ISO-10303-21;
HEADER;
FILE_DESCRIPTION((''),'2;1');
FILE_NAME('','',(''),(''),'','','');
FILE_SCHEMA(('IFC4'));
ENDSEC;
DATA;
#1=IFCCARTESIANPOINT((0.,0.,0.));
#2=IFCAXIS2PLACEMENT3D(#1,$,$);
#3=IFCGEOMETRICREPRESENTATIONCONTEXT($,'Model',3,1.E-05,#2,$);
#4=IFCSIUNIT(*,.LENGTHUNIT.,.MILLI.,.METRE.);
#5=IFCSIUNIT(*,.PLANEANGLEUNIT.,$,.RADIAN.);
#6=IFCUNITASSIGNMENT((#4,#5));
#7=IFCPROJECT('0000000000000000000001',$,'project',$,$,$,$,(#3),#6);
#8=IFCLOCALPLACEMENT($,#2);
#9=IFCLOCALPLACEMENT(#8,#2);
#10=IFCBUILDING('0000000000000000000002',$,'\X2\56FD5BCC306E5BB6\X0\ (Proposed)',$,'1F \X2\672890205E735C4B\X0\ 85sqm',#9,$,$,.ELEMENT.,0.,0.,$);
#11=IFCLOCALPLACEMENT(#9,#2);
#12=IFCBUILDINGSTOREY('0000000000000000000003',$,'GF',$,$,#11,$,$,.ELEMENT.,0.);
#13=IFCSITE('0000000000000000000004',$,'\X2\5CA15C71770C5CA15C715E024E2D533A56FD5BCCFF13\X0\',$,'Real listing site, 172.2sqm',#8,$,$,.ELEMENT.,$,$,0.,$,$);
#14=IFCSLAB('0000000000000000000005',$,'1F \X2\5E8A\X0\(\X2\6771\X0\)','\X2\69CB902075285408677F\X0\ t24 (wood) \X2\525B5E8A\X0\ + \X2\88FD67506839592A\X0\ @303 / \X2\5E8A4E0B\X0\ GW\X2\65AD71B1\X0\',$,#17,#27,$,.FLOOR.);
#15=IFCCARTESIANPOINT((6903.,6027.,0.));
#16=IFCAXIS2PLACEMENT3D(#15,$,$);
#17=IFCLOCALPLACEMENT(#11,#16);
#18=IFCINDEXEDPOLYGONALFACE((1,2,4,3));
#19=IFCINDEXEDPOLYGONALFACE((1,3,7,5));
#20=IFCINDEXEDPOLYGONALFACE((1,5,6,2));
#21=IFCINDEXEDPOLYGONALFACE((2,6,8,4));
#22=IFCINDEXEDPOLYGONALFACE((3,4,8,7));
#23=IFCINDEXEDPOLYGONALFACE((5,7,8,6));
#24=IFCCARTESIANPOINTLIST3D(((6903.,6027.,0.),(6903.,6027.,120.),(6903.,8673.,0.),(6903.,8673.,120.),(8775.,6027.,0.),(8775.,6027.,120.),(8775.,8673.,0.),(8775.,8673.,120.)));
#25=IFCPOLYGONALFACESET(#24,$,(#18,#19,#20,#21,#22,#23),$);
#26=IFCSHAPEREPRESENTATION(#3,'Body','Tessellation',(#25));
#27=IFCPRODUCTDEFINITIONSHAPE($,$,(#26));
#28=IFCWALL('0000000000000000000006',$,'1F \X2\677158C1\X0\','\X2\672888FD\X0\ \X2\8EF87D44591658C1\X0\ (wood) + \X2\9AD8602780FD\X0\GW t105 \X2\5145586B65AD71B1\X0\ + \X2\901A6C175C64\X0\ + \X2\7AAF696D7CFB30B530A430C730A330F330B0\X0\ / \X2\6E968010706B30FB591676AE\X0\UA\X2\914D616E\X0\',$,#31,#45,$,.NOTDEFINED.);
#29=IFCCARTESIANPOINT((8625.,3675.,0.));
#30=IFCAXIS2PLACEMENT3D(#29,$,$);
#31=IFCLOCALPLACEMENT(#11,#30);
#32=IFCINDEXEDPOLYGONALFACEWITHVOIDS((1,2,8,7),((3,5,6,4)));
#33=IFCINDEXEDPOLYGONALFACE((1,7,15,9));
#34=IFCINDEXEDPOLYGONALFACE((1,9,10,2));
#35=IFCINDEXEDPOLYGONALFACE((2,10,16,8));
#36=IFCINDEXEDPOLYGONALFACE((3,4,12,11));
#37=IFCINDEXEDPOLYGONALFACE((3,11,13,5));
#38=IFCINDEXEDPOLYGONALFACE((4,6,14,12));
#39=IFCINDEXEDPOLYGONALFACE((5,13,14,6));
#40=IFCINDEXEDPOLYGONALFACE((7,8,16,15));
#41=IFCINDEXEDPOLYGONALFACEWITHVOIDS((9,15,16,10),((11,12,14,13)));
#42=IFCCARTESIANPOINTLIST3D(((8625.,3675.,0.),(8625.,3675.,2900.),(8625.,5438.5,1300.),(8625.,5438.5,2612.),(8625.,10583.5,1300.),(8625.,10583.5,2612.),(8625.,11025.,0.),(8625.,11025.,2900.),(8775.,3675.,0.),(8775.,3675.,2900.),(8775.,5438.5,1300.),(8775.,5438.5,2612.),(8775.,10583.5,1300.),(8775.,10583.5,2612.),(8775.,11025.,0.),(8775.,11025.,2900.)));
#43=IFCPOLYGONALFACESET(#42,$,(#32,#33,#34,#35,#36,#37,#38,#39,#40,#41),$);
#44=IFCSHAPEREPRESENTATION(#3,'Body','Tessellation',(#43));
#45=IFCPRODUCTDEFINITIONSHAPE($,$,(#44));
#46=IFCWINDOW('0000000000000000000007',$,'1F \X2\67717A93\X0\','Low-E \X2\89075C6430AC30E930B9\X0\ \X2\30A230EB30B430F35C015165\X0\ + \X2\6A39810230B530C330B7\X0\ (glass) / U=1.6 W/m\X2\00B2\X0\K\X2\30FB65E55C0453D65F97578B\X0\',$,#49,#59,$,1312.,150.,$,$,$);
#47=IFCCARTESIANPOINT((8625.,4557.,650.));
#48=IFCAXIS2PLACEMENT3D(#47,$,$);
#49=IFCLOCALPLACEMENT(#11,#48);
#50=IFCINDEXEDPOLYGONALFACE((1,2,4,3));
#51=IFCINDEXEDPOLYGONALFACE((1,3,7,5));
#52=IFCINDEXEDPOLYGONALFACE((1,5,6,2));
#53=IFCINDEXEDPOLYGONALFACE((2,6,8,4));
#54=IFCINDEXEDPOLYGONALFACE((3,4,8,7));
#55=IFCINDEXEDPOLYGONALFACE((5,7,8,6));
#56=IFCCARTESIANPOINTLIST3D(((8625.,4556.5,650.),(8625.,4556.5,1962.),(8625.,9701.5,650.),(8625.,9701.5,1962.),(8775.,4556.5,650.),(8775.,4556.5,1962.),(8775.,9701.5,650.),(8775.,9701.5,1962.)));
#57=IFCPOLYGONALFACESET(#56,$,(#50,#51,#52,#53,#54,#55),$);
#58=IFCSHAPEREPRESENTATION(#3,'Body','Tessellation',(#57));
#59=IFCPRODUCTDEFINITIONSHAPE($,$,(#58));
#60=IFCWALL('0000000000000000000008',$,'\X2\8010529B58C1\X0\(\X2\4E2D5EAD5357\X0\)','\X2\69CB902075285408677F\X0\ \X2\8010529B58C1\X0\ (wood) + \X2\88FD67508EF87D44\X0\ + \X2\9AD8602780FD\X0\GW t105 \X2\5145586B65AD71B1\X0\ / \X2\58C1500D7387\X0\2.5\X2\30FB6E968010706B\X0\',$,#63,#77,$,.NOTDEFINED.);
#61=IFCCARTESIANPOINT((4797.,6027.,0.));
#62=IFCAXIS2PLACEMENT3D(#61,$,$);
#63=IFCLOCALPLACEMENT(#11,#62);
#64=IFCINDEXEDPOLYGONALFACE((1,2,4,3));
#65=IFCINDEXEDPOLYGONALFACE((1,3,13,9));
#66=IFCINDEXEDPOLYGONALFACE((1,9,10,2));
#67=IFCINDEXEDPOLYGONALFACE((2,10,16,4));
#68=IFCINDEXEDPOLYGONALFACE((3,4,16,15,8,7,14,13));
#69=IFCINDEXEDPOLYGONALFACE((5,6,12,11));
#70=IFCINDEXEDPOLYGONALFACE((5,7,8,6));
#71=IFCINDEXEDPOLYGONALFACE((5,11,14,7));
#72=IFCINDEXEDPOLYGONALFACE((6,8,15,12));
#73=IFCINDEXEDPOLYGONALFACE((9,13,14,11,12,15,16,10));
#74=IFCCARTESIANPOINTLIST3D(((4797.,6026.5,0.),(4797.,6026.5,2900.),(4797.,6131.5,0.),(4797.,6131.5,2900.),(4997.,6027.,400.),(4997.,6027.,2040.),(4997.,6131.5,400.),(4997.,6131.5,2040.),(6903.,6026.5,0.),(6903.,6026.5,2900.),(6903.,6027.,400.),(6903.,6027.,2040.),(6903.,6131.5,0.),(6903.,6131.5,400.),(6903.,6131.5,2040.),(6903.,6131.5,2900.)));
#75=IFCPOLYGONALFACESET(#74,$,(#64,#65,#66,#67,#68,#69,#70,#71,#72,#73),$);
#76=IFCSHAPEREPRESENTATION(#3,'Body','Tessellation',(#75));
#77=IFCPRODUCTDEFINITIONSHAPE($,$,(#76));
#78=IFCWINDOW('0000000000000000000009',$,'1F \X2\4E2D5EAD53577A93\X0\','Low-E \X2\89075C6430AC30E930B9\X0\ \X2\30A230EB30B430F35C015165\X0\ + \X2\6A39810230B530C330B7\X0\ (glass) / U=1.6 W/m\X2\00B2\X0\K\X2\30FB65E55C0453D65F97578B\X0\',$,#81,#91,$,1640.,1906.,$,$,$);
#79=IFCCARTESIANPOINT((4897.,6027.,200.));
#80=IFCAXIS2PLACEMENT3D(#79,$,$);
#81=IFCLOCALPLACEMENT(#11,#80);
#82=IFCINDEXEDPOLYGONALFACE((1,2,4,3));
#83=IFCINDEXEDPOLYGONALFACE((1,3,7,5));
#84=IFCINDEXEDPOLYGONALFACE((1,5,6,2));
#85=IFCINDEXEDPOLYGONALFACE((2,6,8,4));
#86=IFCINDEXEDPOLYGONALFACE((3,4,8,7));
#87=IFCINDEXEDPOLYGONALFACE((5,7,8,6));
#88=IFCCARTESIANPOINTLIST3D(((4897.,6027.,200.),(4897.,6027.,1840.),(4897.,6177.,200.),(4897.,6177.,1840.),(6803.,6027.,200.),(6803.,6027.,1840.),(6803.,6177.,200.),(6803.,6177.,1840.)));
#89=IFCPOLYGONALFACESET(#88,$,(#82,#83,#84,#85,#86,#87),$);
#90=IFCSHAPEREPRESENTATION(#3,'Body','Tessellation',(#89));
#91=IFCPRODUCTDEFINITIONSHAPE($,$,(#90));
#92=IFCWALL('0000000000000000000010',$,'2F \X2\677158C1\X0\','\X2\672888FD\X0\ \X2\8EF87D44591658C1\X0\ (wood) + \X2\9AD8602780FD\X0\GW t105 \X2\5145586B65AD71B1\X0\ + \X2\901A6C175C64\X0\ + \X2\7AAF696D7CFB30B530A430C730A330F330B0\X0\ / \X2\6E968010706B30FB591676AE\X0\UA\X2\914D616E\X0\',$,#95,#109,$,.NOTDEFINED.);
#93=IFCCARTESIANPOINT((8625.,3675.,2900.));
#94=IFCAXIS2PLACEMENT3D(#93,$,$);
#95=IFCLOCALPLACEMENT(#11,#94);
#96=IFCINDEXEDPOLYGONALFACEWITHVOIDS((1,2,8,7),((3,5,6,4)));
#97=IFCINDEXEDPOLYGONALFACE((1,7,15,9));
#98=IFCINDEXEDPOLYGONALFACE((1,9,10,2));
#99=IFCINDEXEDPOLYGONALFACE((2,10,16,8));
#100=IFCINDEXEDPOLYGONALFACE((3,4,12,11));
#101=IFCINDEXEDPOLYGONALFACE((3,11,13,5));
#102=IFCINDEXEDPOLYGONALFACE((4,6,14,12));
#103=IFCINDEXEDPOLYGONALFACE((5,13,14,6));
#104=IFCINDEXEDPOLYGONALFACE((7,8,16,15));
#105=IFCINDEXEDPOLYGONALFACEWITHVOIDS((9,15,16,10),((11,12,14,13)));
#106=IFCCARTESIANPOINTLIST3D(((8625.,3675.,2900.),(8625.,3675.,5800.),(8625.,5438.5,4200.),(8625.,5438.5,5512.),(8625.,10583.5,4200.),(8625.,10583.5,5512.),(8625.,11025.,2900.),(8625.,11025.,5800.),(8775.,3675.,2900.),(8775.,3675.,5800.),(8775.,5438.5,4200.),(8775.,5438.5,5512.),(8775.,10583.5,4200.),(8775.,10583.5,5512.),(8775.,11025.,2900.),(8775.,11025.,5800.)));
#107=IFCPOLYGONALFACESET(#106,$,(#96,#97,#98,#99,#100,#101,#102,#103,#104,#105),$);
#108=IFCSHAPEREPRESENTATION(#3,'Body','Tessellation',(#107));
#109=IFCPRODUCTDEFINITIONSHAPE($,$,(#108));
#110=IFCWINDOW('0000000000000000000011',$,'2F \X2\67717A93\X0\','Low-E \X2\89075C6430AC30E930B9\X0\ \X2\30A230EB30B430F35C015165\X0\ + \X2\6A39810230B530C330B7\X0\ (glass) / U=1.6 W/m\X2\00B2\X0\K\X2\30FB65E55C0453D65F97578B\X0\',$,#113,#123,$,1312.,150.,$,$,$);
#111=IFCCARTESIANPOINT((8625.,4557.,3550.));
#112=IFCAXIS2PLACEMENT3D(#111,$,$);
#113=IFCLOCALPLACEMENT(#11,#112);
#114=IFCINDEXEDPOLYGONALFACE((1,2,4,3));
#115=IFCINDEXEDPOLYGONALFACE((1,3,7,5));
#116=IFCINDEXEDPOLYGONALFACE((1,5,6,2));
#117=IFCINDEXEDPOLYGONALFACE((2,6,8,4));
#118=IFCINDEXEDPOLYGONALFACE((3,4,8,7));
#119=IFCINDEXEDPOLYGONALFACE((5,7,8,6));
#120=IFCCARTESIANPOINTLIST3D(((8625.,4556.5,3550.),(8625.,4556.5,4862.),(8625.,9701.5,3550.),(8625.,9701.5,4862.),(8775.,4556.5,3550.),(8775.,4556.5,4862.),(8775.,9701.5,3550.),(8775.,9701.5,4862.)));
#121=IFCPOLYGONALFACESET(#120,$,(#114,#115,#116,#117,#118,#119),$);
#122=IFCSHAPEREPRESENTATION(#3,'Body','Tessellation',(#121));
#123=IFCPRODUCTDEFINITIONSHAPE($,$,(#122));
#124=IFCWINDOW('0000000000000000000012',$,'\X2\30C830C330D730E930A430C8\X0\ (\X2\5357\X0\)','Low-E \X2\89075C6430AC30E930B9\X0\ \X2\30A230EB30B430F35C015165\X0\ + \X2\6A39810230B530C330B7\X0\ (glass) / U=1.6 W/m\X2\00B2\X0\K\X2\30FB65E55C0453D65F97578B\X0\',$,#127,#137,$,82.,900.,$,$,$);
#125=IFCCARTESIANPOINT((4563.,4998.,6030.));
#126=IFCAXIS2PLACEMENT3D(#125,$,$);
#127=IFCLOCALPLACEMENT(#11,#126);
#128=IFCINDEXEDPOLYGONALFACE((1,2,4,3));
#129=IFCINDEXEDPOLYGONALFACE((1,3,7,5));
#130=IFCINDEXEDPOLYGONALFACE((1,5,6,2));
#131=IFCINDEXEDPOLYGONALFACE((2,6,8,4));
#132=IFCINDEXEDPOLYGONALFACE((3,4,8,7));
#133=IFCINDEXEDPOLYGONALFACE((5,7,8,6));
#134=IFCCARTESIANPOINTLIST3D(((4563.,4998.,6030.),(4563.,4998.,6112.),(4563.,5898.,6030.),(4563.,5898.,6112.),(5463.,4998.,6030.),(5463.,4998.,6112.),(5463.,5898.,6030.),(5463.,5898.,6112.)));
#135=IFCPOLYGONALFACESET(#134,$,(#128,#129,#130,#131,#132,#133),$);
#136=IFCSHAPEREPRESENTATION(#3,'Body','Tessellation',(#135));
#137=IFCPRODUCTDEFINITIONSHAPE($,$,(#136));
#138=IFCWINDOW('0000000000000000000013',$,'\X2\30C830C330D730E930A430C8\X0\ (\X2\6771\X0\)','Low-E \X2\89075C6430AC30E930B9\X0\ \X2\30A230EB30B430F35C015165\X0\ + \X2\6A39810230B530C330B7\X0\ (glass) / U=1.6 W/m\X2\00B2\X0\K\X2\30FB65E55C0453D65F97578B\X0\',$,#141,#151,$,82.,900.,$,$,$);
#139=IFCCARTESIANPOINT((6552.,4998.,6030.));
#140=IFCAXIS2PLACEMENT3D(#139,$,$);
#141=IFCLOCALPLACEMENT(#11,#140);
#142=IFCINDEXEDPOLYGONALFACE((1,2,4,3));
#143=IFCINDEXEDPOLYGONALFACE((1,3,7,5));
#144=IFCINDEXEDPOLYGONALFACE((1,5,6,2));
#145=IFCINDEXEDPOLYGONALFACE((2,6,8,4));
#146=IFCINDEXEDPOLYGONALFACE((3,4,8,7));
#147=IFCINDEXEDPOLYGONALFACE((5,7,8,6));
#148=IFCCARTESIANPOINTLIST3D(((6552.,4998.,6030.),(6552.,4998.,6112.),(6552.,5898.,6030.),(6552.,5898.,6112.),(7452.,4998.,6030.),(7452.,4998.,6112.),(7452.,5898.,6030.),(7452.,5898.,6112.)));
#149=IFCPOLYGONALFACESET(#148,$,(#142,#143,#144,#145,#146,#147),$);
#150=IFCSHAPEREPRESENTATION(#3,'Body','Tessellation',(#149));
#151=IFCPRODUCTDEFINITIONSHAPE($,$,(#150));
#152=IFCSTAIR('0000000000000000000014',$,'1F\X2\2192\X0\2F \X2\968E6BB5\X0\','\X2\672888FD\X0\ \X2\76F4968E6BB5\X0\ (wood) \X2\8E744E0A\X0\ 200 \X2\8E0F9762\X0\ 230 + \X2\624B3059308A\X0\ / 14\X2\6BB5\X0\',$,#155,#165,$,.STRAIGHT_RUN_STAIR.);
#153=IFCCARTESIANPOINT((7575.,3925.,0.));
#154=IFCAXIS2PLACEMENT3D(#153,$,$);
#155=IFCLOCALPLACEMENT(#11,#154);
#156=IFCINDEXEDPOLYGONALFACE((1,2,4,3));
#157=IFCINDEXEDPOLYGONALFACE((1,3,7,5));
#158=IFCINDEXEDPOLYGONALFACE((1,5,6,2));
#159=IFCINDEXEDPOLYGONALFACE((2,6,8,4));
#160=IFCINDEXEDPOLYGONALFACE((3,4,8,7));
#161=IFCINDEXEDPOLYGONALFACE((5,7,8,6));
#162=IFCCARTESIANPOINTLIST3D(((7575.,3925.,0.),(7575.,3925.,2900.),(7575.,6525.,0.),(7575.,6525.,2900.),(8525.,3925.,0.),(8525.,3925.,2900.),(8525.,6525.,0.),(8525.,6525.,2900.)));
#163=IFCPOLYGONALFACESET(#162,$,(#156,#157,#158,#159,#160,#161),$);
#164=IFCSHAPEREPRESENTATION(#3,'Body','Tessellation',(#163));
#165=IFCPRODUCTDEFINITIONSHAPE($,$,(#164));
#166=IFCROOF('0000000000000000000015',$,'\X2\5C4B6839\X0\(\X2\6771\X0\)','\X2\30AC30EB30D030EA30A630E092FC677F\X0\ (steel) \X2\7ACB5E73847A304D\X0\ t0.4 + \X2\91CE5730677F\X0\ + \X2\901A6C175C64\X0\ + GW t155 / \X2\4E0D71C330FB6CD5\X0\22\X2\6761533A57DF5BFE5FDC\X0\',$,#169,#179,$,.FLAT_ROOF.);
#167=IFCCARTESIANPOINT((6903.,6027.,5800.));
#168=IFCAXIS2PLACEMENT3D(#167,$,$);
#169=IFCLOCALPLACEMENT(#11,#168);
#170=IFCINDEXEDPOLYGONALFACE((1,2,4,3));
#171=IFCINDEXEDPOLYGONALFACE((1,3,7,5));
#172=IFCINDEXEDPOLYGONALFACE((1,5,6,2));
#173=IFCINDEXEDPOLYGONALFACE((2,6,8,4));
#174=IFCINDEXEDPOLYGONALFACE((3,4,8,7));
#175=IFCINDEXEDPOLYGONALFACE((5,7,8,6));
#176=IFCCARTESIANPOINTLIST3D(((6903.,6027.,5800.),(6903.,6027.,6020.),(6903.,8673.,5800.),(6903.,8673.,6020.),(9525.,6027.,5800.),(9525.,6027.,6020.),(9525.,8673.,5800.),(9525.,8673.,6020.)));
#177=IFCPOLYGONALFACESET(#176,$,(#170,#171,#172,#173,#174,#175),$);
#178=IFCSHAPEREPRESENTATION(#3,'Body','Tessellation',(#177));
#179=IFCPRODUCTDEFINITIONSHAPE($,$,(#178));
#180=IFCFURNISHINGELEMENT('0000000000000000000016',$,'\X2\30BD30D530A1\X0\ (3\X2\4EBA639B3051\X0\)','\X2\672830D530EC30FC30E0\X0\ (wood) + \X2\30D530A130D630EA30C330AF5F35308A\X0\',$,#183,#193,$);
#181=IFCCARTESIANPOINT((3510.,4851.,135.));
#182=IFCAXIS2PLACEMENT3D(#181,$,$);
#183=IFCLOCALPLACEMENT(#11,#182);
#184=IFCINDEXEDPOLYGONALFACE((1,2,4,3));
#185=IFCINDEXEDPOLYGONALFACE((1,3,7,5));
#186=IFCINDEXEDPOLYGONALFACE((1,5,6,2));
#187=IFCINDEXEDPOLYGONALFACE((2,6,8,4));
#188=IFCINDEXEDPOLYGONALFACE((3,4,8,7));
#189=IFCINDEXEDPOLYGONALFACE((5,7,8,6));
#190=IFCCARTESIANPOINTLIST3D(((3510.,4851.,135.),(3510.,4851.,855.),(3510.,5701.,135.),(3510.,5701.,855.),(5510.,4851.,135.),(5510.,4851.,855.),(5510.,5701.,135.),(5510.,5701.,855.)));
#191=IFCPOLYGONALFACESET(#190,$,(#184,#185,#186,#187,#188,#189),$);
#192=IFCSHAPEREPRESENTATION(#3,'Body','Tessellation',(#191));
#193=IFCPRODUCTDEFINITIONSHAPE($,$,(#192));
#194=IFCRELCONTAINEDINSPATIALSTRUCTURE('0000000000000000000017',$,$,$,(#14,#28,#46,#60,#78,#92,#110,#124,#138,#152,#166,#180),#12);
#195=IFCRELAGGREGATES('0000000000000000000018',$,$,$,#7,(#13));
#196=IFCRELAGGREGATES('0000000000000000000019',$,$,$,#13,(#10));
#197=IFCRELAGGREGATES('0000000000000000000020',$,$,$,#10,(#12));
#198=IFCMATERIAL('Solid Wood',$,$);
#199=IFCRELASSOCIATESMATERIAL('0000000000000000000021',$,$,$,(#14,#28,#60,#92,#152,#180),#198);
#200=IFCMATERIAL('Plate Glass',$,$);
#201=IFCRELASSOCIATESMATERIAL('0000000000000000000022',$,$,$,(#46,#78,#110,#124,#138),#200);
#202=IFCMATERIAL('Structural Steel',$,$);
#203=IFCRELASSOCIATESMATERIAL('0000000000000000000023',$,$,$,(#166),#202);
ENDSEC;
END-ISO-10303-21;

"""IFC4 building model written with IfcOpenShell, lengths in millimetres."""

from ifc_helpers import new_model, si_unit, frame, frame_2d, origin, place, context, project, spatial, rectangle, extrude, material, element, fill, save


model = new_model("IFC4")

# Units and contexts
model_context = context("Model", 3, precision=1e-05, world=origin())
ifc_project = project(units=[si_unit("LENGTHUNIT", "METRE", prefix="MILLI"), si_unit("PLANEANGLEUNIT", "RADIAN")], contexts=[model_context])

# Site, building, storey
site_placement = place(None, origin())
site = spatial("IfcSite", under=ifc_project, at=site_placement, Name="岡山県岡山市中区国富３", ObjectType="Real listing site, 172.2sqm", CompositionType="ELEMENT", RefElevation=0.0)
building_placement = place(site_placement, origin())
building = spatial("IfcBuilding", under=site, at=building_placement, Name="国富の家 (Proposed)", ObjectType="1F 木造平屋 85sqm", CompositionType="ELEMENT", ElevationOfRefHeight=0.0, ElevationOfTerrain=0.0)
storey_placement = place(building_placement, origin())
storey = spatial("IfcBuildingStorey", under=building, at=storey_placement, Name="GF", CompositionType="ELEMENT", Elevation=0.0)

# Slab
ifc_material_1 = material(Name="Solid Wood")
slab_placement = place(storey_placement, frame((6903.0, 6027.0, 0.0)))
element("IfcSlab", 1, at=slab_placement, inside=storey, material=ifc_material_1, Name="1F 床(東)", Description="構造用合板 t24 (wood) 剛床 + 製材根太 @303 / 床下 GW断熱", PredefinedType="FLOOR", context=model_context, shape_type="SweptSolid", body=[
    extrude(rectangle(XDim=1872.0, YDim=2646.0, at=frame_2d((936.0, 1323.0))), frame((6903.0, 6027.0, 0.0)), (0.0, 0.0, 1.0), 120.0),
])

# Walls, openings, windows
wall_1_placement = place(storey_placement, frame((8625.0, 3675.0, 0.0)))
wall_1 = element("IfcWall", 2, at=wall_1_placement, inside=storey, material=ifc_material_1, Name="1F 東壁", Description="木製 軸組外壁 (wood) + 高性能GW t105 充填断熱 + 通気層 + 窯業系サイディング / 準耐火・外皮UA配慮", PredefinedType="NOTDEFINED", context=model_context, shape_type="SweptSolid", body=[
    extrude(rectangle(XDim=150.0, YDim=7350.0, at=frame_2d((75.0, 3675.0))), frame((8625.0, 3675.0, 0.0)), (0.0, 0.0, 1.0), 2900.0),
])
opening_1_placement = place(storey_placement, frame((8625.0, 4557.0, 650.0)))
opening_1 = element("IfcOpeningElement", 3, at=opening_1_placement, cuts=wall_1, PredefinedType="NOTDEFINED", context=model_context, shape_type="SweptSolid", body=[
    extrude(rectangle(XDim=150.0, YDim=5145.0, at=frame_2d((75.0, 2572.0))), frame((8625.0, 4557.0, 650.0)), (0.0, 0.0, 1.0), 1312.0),
])
ifc_material_2 = material(Name="Plate Glass")
window_1_placement = place(storey_placement, frame((8625.0, 4557.0, 650.0)))
window_1 = element("IfcWindow", 4, at=window_1_placement, inside=storey, material=ifc_material_2, Name="1F 東窓", Description="Low-E 複層ガラス アルゴン封入 + 樹脂サッシ (glass) / U=1.6 W/m²K・日射取得型", OverallHeight=1312.0, OverallWidth=150.0, context=model_context, shape_type="SweptSolid", body=[
    extrude(rectangle(XDim=150.0, YDim=5145.0, at=frame_2d((75.0, 2572.0))), frame((8625.0, 4557.0, 650.0)), (0.0, 0.0, 1.0), 1312.0),
])
fill(opening_1, window_1)
wall_2_placement = place(storey_placement, frame((4797.0, 6027.0, 0.0)))
wall_2 = element("IfcWall", 5, at=wall_2_placement, inside=storey, material=ifc_material_1, Name="耐力壁(中庭南)", Description="構造用合板 耐力壁 (wood) + 製材軸組 + 高性能GW t105 充填断熱 / 壁倍率2.5・準耐火", PredefinedType="NOTDEFINED", context=model_context, shape_type="SweptSolid", body=[
    extrude(rectangle(XDim=2106.0, YDim=105.0, at=frame_2d((1053.0, 52.0))), frame((4797.0, 6027.0, 0.0)), (0.0, 0.0, 1.0), 2900.0),
])
opening_2_placement = place(storey_placement, frame((4897.0, 6027.0, 200.0)))
opening_2 = element("IfcOpeningElement", 6, at=opening_2_placement, cuts=wall_2, PredefinedType="NOTDEFINED", context=model_context, shape_type="SweptSolid", body=[
    extrude(rectangle(XDim=1906.0, YDim=150.0, at=frame_2d((953.0, 75.0))), frame((4897.0, 6027.0, 200.0)), (0.0, 0.0, 1.0), 1640.0),
])
window_2_placement = place(storey_placement, frame((4897.0, 6027.0, 200.0)))
window_2 = element("IfcWindow", 7, at=window_2_placement, inside=storey, material=ifc_material_2, Name="1F 中庭南窓", Description="Low-E 複層ガラス アルゴン封入 + 樹脂サッシ (glass) / U=1.6 W/m²K・日射取得型", OverallHeight=1640.0, OverallWidth=1906.0, context=model_context, shape_type="SweptSolid", body=[
    extrude(rectangle(XDim=1906.0, YDim=150.0, at=frame_2d((953.0, 75.0))), frame((4897.0, 6027.0, 200.0)), (0.0, 0.0, 1.0), 1640.0),
])
fill(opening_2, window_2)

# Wall, opening, window
wall_3_placement = place(storey_placement, frame((8625.0, 3675.0, 2900.0)))
wall_3 = element("IfcWall", 8, at=wall_3_placement, inside=storey, material=ifc_material_1, Name="2F 東壁", Description="木製 軸組外壁 (wood) + 高性能GW t105 充填断熱 + 通気層 + 窯業系サイディング / 準耐火・外皮UA配慮", PredefinedType="NOTDEFINED", context=model_context, shape_type="SweptSolid", body=[
    extrude(rectangle(XDim=150.0, YDim=7350.0, at=frame_2d((75.0, 3675.0))), frame((8625.0, 3675.0, 2900.0)), (0.0, 0.0, 1.0), 2900.0),
])
opening_3_placement = place(storey_placement, frame((8625.0, 4557.0, 3550.0)))
opening_3 = element("IfcOpeningElement", 9, at=opening_3_placement, cuts=wall_3, PredefinedType="NOTDEFINED", context=model_context, shape_type="SweptSolid", body=[
    extrude(rectangle(XDim=150.0, YDim=5145.0, at=frame_2d((75.0, 2572.0))), frame((8625.0, 4557.0, 3550.0)), (0.0, 0.0, 1.0), 1312.0),
])
window_3_placement = place(storey_placement, frame((8625.0, 4557.0, 3550.0)))
window_3 = element("IfcWindow", 10, at=window_3_placement, inside=storey, material=ifc_material_2, Name="2F 東窓", Description="Low-E 複層ガラス アルゴン封入 + 樹脂サッシ (glass) / U=1.6 W/m²K・日射取得型", OverallHeight=1312.0, OverallWidth=150.0, context=model_context, shape_type="SweptSolid", body=[
    extrude(rectangle(XDim=150.0, YDim=5145.0, at=frame_2d((75.0, 2572.0))), frame((8625.0, 4557.0, 3550.0)), (0.0, 0.0, 1.0), 1312.0),
])
fill(opening_3, window_3)

# Windows
window_4_placement = place(storey_placement, frame((4563.0, 4998.0, 6030.0)))
element("IfcWindow", 11, at=window_4_placement, inside=storey, material=ifc_material_2, Name="トップライト (南)", Description="Low-E 複層ガラス アルゴン封入 + 樹脂サッシ (glass) / U=1.6 W/m²K・日射取得型", OverallHeight=82.0, OverallWidth=900.0, context=model_context, shape_type="SweptSolid", body=[
    extrude(rectangle(XDim=900.0, YDim=900.0, at=frame_2d((450.0, 450.0))), frame((4563.0, 4998.0, 6030.0)), (0.0, 0.0, 1.0), 82.0),
])
window_5_placement = place(storey_placement, frame((6552.0, 4998.0, 6030.0)))
element("IfcWindow", 12, at=window_5_placement, inside=storey, material=ifc_material_2, Name="トップライト (東)", Description="Low-E 複層ガラス アルゴン封入 + 樹脂サッシ (glass) / U=1.6 W/m²K・日射取得型", OverallHeight=82.0, OverallWidth=900.0, context=model_context, shape_type="SweptSolid", body=[
    extrude(rectangle(XDim=900.0, YDim=900.0, at=frame_2d((450.0, 450.0))), frame((6552.0, 4998.0, 6030.0)), (0.0, 0.0, 1.0), 82.0),
])

# Stair
stair_placement = place(storey_placement, frame((7575.0, 3925.0, 0.0)))
element("IfcStair", 13, at=stair_placement, inside=storey, material=ifc_material_1, Name="1F→2F 階段", Description="木製 直階段 (wood) 蹴上 200 踏面 230 + 手すり / 14段", PredefinedType="STRAIGHT_RUN_STAIR", context=model_context, shape_type="SweptSolid", body=[
    extrude(rectangle(XDim=950.0, YDim=2600.0, at=frame_2d((475.0, 1300.0))), frame((7575.0, 3925.0, 0.0)), (0.0, 0.0, 1.0), 2900.0),
])

# Roof
ifc_material_3 = material(Name="Structural Steel")
roof_placement = place(storey_placement, frame((6903.0, 6027.0, 5800.0)))
element("IfcRoof", 14, at=roof_placement, inside=storey, material=ifc_material_3, Name="屋根(東)", Description="ガルバリウム鋼板 (steel) 立平葺き t0.4 + 野地板 + 通気層 + GW t155 / 不燃・法22条区域対応", PredefinedType="FLAT_ROOF", context=model_context, shape_type="SweptSolid", body=[
    extrude(rectangle(XDim=2622.0, YDim=2646.0, at=frame_2d((1311.0, 1323.0))), frame((6903.0, 6027.0, 5800.0)), (0.0, 0.0, 1.0), 220.0),
])

# Furnishing element
furnishing_1_placement = place(storey_placement, frame((3510.0, 4851.0, 135.0)))
element("IfcFurnishingElement", 15, at=furnishing_1_placement, inside=storey, material=ifc_material_1, Name="ソファ (3人掛け)", Description="木フレーム (wood) + ファブリック張り", context=model_context, shape_type="SweptSolid", body=[
    extrude(rectangle(XDim=2000.0, YDim=850.0, at=frame_2d((1000.0, 425.0))), frame((3510.0, 4851.0, 135.0)), (0.0, 0.0, 1.0), 720.0),
])

save(model, "model.ifc")
